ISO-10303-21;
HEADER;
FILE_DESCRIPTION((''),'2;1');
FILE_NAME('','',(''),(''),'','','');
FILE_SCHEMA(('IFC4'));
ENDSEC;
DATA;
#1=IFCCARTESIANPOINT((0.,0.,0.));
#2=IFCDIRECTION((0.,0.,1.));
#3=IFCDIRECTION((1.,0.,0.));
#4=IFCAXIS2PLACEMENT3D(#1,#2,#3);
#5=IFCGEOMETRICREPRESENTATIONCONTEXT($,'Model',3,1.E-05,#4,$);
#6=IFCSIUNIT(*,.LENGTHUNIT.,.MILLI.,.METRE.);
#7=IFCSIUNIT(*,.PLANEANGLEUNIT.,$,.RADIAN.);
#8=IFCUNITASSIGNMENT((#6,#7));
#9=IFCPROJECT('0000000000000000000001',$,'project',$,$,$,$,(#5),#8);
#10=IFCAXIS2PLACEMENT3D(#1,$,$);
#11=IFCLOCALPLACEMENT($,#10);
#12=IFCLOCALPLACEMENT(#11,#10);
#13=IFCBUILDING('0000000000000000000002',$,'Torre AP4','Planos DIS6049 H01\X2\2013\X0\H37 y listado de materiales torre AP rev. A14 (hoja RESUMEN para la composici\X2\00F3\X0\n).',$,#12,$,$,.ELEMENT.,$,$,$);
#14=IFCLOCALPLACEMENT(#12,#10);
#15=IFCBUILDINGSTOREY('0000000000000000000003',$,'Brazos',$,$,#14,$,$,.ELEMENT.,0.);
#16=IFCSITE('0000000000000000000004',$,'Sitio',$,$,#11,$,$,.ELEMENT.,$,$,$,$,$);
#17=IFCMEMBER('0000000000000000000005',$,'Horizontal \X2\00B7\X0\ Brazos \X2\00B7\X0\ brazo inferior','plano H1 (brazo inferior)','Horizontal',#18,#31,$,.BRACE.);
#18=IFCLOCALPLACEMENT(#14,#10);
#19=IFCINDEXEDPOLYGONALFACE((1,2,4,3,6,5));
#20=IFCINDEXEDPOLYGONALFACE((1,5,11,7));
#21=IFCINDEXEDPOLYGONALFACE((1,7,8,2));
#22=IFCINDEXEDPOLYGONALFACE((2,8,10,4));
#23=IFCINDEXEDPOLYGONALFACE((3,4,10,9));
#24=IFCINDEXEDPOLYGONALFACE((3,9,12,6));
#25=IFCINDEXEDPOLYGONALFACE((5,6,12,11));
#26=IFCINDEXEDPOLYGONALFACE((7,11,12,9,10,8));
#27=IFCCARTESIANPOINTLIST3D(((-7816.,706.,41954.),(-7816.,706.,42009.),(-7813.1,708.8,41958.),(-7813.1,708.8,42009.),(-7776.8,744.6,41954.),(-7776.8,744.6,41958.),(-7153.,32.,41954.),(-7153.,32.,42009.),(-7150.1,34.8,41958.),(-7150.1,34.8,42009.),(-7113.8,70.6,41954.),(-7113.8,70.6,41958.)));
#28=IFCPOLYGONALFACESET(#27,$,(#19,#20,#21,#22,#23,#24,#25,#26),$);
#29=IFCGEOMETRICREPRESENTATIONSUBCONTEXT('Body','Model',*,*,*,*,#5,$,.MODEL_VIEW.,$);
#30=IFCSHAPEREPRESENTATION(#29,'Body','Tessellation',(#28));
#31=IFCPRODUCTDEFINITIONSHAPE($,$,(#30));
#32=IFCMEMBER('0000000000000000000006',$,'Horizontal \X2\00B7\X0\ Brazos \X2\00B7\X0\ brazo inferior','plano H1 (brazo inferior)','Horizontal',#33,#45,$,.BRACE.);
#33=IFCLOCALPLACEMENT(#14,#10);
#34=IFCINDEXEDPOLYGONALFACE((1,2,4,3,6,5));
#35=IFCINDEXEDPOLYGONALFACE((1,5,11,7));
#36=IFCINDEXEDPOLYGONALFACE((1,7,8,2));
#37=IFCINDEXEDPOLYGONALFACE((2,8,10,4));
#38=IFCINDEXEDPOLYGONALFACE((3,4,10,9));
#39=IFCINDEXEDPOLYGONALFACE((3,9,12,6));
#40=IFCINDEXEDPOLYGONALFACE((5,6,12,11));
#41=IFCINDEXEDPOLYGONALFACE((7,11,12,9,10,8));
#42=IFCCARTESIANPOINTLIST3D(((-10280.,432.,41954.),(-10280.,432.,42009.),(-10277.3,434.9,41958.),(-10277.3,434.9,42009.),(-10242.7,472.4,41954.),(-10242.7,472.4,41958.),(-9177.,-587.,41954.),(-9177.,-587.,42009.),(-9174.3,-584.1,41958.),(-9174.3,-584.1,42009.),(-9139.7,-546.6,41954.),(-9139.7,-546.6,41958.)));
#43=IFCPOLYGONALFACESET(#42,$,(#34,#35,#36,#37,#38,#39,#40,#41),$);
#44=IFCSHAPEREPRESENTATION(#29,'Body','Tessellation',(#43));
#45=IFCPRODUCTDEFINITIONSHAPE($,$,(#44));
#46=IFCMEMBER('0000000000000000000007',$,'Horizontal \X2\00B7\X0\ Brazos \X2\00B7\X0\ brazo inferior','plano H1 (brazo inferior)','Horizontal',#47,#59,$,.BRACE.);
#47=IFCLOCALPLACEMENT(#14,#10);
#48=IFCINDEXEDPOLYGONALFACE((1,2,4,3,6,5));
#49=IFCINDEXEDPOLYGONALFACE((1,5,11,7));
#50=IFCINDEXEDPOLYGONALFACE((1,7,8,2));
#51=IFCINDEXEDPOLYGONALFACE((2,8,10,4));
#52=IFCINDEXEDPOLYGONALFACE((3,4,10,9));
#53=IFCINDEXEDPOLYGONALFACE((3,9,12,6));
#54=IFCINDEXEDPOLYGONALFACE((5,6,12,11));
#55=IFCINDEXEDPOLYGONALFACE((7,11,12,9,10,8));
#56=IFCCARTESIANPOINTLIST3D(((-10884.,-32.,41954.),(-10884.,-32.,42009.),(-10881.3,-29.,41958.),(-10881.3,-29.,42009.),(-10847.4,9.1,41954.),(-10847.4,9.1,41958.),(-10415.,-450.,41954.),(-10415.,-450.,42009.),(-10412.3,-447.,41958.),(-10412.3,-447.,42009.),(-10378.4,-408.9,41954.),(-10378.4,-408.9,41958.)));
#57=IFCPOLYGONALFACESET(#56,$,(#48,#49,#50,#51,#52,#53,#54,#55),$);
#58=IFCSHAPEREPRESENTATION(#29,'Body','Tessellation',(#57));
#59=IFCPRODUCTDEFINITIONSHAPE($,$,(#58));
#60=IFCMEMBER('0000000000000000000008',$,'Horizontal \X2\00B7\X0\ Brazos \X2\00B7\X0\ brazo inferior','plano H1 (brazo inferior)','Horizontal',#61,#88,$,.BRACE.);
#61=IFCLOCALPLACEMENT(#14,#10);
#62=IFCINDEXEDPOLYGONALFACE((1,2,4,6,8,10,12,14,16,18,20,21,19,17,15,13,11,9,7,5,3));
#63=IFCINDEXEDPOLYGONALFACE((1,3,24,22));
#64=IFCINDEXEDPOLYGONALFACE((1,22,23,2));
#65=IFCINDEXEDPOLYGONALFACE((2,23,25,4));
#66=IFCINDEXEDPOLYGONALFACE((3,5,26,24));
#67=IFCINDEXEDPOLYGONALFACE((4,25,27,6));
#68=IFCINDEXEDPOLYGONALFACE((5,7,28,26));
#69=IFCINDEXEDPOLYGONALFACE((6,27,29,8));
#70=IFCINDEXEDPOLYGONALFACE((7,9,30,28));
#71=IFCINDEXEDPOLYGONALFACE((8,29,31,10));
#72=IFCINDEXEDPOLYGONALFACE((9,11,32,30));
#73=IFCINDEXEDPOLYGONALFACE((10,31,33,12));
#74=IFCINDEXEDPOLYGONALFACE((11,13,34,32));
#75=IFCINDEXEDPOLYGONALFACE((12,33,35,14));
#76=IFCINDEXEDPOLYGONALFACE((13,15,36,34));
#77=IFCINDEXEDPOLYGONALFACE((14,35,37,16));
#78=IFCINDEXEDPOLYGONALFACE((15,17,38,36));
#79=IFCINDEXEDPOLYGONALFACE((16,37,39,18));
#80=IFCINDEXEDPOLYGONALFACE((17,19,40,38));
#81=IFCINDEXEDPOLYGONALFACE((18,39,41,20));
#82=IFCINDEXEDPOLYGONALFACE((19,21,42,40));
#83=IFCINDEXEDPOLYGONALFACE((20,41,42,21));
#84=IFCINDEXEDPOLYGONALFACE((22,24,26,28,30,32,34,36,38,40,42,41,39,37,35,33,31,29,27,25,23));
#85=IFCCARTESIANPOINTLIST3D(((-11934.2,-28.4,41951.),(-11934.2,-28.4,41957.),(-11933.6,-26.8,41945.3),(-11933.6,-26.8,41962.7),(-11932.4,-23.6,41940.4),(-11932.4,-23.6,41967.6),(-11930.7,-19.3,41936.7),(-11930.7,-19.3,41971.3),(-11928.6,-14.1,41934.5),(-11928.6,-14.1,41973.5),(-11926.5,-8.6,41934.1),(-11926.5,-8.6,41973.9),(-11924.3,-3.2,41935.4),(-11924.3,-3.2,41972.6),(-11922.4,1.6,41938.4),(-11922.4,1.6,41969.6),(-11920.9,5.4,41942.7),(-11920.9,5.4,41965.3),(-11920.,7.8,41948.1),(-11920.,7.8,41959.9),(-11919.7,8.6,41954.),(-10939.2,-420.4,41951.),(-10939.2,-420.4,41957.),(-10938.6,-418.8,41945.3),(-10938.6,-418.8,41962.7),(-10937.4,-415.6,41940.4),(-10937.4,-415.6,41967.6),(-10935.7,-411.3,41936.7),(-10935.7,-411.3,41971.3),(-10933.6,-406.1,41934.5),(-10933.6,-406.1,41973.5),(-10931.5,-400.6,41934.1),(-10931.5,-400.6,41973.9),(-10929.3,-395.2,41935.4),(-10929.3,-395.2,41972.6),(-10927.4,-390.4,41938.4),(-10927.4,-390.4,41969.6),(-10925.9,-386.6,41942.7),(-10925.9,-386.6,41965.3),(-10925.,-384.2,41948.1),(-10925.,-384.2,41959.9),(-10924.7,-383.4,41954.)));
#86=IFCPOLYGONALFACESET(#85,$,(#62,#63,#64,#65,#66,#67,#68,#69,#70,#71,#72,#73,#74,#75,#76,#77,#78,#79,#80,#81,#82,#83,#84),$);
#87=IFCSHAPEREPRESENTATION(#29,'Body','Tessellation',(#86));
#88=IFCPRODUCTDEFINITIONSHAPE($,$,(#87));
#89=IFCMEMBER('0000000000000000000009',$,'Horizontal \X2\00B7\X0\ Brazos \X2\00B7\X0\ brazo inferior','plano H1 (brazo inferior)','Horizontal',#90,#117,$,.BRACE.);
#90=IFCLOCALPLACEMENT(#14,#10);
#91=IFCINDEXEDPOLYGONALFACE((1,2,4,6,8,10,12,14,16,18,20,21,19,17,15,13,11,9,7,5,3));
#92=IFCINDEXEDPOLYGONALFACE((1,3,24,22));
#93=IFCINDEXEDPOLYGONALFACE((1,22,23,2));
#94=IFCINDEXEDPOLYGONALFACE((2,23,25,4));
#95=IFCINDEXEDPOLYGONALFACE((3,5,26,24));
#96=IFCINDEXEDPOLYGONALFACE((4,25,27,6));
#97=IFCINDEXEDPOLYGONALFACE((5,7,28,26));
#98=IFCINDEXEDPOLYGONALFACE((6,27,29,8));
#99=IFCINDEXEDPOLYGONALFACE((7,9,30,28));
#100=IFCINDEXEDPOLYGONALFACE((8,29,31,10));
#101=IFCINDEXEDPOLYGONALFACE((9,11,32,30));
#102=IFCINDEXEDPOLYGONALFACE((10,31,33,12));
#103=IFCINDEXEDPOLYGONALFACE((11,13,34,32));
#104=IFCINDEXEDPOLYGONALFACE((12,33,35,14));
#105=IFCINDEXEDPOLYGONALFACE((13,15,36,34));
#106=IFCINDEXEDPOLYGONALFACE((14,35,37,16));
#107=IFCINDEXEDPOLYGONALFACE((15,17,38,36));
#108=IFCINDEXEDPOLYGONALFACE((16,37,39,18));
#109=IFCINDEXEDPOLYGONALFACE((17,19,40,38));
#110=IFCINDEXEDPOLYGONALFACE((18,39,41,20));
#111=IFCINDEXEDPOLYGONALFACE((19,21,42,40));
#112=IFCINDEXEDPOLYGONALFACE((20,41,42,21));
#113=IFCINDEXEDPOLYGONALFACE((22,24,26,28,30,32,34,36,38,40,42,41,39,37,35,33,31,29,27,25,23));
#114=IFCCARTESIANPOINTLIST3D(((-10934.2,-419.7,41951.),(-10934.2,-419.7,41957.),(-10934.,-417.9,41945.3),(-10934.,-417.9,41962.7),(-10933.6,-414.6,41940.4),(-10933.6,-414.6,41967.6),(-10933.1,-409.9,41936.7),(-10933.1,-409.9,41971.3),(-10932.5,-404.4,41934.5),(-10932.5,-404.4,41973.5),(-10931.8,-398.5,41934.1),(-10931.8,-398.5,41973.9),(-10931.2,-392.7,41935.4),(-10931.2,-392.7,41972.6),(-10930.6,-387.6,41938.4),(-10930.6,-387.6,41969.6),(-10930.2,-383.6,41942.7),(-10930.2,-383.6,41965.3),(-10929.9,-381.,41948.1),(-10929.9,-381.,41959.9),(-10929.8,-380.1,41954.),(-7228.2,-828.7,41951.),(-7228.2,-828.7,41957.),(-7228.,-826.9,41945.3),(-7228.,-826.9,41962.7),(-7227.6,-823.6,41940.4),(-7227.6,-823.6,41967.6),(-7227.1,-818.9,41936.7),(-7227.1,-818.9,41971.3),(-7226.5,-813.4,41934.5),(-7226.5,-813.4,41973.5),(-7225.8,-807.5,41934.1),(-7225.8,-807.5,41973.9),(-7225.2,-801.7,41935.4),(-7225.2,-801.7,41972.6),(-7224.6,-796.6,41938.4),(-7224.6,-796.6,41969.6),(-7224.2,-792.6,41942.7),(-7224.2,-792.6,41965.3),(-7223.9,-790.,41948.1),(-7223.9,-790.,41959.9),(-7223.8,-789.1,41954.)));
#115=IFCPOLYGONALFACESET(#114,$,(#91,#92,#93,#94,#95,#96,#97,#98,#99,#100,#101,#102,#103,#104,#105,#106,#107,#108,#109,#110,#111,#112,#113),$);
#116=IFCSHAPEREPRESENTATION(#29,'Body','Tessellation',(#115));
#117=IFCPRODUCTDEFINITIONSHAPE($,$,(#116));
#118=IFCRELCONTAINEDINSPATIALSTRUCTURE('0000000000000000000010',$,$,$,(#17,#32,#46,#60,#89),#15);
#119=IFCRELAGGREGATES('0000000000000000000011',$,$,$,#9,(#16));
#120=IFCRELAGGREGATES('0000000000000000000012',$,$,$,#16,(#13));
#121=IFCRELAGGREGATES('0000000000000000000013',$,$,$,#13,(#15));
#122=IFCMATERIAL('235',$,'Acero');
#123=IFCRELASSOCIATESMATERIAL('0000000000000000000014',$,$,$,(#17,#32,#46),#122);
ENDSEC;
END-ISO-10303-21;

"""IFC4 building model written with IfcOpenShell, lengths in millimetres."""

from ifc_helpers import new_model, si_unit, frame, frame_2d, origin, origin_with_axes, place, context, subcontext, project, spatial, circle, l_section, extrude, material, element, save


model = new_model("IFC4")

# Units and contexts
model_context = context("Model", 3, precision=1e-05, world=origin_with_axes())
body_context = subcontext(model_context, "Body", "Model", "MODEL_VIEW")
ifc_project = project(units=[si_unit("LENGTHUNIT", "METRE", prefix="MILLI"), si_unit("PLANEANGLEUNIT", "RADIAN")], contexts=[model_context])

# Site, building, storey
site_placement = place(None, origin())
site = spatial("IfcSite", under=ifc_project, at=site_placement, Name="Sitio", CompositionType="ELEMENT")
building_placement = place(site_placement, origin())
building = spatial("IfcBuilding", under=site, at=building_placement, Name="Torre AP4", Description="Planos DIS6049 H01–H37 y listado de materiales torre AP rev. A14 (hoja RESUMEN para la composición).", CompositionType="ELEMENT")
storey_placement = place(building_placement, origin())
storey = spatial("IfcBuildingStorey", under=building, at=storey_placement, Name="Brazos", CompositionType="ELEMENT", Elevation=0.0)

# Members
ifc_material_1 = material(Name="235", Category="Acero")
member_1_placement = place(storey_placement, frame((-7816.0, 706.0, 41954.0), z_axis=(0.701265, -0.7129, 0.0), x_axis=(0.7129, 0.701265, 0.0)))
element("IfcMember", 1, at=member_1_placement, inside=storey, material=ifc_material_1, Name="Horizontal · Brazos · brazo inferior", Description="plano H1 (brazo inferior)", ObjectType="Horizontal", PredefinedType="BRACE", context=body_context, shape_type="SweptSolid", body=[
    extrude(l_section(Depth=55.0, Width=55.0, Thickness=4.0, at=frame_2d((27.5, 27.5))), None, (0.0, 0.0, 1.0), 945.4),
])
member_2_placement = place(storey_placement, frame((-10280.0, 432.0, 41954.0), z_axis=(0.734523, -0.678584, 0.0), x_axis=(0.678584, 0.734523, 0.0)))
element("IfcMember", 2, at=member_2_placement, inside=storey, material=ifc_material_1, Name="Horizontal · Brazos · brazo inferior", Description="plano H1 (brazo inferior)", ObjectType="Horizontal", PredefinedType="BRACE", context=body_context, shape_type="SweptSolid", body=[
    extrude(l_section(Depth=55.0, Width=55.0, Thickness=4.0, at=frame_2d((27.5, 27.5))), None, (0.0, 0.0, 1.0), 1501.7),
])
member_3_placement = place(storey_placement, frame((-10884.0, -32.0, 41954.0), z_axis=(0.74653, -0.665351, 0.0), x_axis=(0.665351, 0.74653, 0.0)))
element("IfcMember", 3, at=member_3_placement, inside=storey, material=ifc_material_1, Name="Horizontal · Brazos · brazo inferior", Description="plano H1 (brazo inferior)", ObjectType="Horizontal", PredefinedType="BRACE", context=body_context, shape_type="SweptSolid", body=[
    extrude(l_section(Depth=55.0, Width=55.0, Thickness=4.0, at=frame_2d((27.5, 27.5))), None, (0.0, 0.0, 1.0), 628.2),
])
member_4_placement = place(storey_placement, frame((-11927.0, -10.0, 41954.0), z_axis=(0.930399, -0.366549, 0.0), x_axis=(0.366549, 0.930399, 0.0)))
element("IfcMember", 4, at=member_4_placement, inside=storey, Name="Horizontal · Brazos · brazo inferior", Description="plano H1 (brazo inferior)", ObjectType="Horizontal", PredefinedType="BRACE", context=body_context, shape_type="SweptSolid", body=[
    extrude(circle(Radius=20.0), None, (0.0, 0.0, 1.0), 1069.4),
])
member_5_placement = place(storey_placement, frame((-10932.0, -400.0, 41954.0), z_axis=(0.993965, -0.109696, 0.0), x_axis=(0.109696, 0.993965, 0.0)))
element("IfcMember", 5, at=member_5_placement, inside=storey, Name="Horizontal · Brazos · brazo inferior", Description="plano H1 (brazo inferior)", ObjectType="Horizontal", PredefinedType="BRACE", context=body_context, shape_type="SweptSolid", body=[
    extrude(circle(Radius=20.0), None, (0.0, 0.0, 1.0), 3728.5),
])

save(model, "model.ifc")
